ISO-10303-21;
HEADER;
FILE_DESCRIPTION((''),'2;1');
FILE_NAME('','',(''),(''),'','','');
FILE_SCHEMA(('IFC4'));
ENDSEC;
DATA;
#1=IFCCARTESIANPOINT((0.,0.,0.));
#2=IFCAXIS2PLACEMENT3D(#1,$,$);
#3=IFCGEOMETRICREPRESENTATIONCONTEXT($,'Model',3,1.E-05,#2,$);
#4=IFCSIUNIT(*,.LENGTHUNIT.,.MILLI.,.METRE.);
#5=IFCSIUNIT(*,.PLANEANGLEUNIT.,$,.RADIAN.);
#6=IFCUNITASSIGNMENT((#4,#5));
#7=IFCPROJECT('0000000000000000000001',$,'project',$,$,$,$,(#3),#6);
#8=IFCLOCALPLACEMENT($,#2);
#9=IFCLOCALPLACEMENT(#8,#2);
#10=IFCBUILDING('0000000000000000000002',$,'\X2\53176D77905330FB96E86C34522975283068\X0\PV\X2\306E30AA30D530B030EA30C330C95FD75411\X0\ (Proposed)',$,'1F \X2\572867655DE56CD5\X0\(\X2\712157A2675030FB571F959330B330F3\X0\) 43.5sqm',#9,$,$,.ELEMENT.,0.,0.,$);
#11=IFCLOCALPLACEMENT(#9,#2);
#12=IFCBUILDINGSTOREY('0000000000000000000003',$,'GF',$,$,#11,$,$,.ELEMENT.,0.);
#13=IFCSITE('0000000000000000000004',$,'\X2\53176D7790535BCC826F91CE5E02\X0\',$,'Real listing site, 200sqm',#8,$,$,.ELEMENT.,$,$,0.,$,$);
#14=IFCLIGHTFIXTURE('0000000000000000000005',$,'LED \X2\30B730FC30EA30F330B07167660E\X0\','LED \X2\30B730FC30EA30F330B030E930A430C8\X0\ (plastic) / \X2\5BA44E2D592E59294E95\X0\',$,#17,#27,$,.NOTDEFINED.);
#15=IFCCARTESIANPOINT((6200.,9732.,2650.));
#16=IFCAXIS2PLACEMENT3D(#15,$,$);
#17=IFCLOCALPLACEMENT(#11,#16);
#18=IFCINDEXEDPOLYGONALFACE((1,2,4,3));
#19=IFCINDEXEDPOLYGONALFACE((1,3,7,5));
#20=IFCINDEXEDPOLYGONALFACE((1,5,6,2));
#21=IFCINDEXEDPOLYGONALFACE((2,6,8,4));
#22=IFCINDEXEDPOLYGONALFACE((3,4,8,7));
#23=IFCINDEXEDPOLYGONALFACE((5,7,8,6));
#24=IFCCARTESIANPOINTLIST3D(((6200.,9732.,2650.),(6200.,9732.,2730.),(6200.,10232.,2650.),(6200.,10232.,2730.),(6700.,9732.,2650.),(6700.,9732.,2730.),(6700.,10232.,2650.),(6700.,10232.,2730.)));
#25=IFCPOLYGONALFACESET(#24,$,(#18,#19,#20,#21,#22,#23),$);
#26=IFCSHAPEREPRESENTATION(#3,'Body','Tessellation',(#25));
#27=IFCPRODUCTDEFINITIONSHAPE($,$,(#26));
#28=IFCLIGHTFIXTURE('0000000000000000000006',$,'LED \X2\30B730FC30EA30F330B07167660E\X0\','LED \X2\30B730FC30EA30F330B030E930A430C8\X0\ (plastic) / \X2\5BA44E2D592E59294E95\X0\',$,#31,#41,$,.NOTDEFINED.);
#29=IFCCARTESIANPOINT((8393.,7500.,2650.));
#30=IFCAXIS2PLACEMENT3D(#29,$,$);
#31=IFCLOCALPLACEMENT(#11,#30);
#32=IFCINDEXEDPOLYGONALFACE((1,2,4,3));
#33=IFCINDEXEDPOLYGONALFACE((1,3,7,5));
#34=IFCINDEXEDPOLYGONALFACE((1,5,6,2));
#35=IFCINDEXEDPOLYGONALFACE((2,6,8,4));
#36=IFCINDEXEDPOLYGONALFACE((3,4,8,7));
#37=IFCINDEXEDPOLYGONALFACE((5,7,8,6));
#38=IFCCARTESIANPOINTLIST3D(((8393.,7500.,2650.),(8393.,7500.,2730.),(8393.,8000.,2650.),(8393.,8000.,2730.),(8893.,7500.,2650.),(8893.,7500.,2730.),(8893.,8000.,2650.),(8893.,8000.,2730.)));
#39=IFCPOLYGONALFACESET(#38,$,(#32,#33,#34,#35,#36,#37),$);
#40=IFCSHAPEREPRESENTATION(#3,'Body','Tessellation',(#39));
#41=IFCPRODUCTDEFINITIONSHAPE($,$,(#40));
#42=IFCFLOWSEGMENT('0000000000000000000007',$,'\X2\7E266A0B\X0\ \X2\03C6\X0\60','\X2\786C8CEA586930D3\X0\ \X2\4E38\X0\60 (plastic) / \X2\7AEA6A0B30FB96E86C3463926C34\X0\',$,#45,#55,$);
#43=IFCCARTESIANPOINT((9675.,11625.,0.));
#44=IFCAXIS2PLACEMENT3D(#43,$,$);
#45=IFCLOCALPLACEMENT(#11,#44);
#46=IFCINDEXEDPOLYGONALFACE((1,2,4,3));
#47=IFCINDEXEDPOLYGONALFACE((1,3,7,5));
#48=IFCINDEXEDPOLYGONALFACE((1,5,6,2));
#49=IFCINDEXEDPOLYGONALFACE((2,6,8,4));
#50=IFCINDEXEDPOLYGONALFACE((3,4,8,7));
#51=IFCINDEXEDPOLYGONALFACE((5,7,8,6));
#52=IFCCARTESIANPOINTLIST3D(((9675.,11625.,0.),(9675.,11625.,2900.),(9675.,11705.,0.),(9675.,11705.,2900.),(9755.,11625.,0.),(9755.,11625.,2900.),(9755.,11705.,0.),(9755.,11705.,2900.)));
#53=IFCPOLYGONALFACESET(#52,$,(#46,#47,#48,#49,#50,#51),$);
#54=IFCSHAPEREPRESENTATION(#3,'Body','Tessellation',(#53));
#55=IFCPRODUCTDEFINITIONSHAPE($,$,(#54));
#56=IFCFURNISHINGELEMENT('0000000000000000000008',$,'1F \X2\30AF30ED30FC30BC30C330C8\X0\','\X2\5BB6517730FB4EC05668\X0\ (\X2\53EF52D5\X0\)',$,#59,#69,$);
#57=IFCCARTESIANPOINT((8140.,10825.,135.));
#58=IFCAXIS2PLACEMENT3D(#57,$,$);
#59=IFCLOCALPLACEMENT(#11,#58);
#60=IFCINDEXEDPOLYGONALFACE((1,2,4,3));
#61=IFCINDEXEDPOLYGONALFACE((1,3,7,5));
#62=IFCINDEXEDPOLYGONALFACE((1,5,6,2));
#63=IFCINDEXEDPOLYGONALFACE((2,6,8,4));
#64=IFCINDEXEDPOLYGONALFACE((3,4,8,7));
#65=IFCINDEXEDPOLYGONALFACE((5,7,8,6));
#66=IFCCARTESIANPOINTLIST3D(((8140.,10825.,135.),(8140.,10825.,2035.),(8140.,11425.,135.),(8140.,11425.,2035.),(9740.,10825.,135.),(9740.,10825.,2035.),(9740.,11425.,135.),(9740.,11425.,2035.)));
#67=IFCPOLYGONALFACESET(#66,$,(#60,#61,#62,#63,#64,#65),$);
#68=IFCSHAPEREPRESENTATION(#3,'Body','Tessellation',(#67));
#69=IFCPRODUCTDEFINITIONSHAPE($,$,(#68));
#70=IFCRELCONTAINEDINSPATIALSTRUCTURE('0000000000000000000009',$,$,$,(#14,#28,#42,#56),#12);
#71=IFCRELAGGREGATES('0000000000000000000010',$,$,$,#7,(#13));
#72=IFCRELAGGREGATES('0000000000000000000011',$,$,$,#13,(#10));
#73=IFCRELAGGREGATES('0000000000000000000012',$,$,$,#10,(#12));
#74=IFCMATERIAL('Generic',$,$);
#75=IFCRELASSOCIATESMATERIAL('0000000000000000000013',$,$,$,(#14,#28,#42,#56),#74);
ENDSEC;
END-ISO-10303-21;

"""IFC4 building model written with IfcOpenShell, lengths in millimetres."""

from ifc_helpers import new_model, si_unit, frame, frame_2d, origin, place, context, project, spatial, rectangle, extrude, material, element, save


model = new_model("IFC4")

# Units and contexts
model_context = context("Model", 3, precision=1e-05, world=origin())
ifc_project = project(units=[si_unit("LENGTHUNIT", "METRE", prefix="MILLI"), si_unit("PLANEANGLEUNIT", "RADIAN")], contexts=[model_context])

# Site, building, storey
site_placement = place(None, origin())
site = spatial("IfcSite", under=ifc_project, at=site_placement, Name="北海道富良野市", ObjectType="Real listing site, 200sqm", CompositionType="ELEMENT", RefElevation=0.0)
building_placement = place(site_placement, origin())
building = spatial("IfcBuilding", under=site, at=building_placement, Name="北海道・雨水利用とPVのオフグリッド志向 (Proposed)", ObjectType="1F 在来工法(無垢材・土間コン) 43.5sqm", CompositionType="ELEMENT", ElevationOfRefHeight=0.0, ElevationOfTerrain=0.0)
storey_placement = place(building_placement, origin())
storey = spatial("IfcBuildingStorey", under=building, at=storey_placement, Name="GF", CompositionType="ELEMENT", Elevation=0.0)

# Shared definitions
ifc_material_1 = material(Name="Generic")

# Light fixtures
light_fixture_1_placement = place(storey_placement, frame((6200.0, 9732.0, 2650.0)))
element("IfcLightFixture", 1, at=light_fixture_1_placement, inside=storey, material=ifc_material_1, Name="LED シーリング照明", Description="LED シーリングライト (plastic) / 室中央天井", PredefinedType="NOTDEFINED", context=model_context, shape_type="SweptSolid", body=[
    extrude(rectangle(XDim=500.0, YDim=500.0, at=frame_2d((250.0, 250.0))), frame((6200.0, 9732.0, 2650.0)), (0.0, 0.0, 1.0), 80.0),
])
light_fixture_2_placement = place(storey_placement, frame((8393.0, 7500.0, 2650.0)))
element("IfcLightFixture", 2, at=light_fixture_2_placement, inside=storey, material=ifc_material_1, Name="LED シーリング照明", Description="LED シーリングライト (plastic) / 室中央天井", PredefinedType="NOTDEFINED", context=model_context, shape_type="SweptSolid", body=[
    extrude(rectangle(XDim=500.0, YDim=500.0, at=frame_2d((250.0, 250.0))), frame((8393.0, 7500.0, 2650.0)), (0.0, 0.0, 1.0), 80.0),
])

# Flow segment
flow_segment_placement = place(storey_placement, frame((9675.0, 11625.0, 0.0)))
element("IfcFlowSegment", 3, at=flow_segment_placement, inside=storey, material=ifc_material_1, Name="縦樋 φ60", Description="硬質塩ビ 丸60 (plastic) / 竪樋・雨水排水", context=model_context, shape_type="SweptSolid", body=[
    extrude(rectangle(XDim=80.0, YDim=80.0, at=frame_2d((40.0, 40.0))), frame((9675.0, 11625.0, 0.0)), (0.0, 0.0, 1.0), 2900.0),
])

# Furnishing element
furnishing_placement = place(storey_placement, frame((8140.0, 10825.0, 135.0)))
element("IfcFurnishingElement", 4, at=furnishing_placement, inside=storey, material=ifc_material_1, Name="1F クローゼット", Description="家具・什器 (可動)", context=model_context, shape_type="SweptSolid", body=[
    extrude(rectangle(XDim=1600.0, YDim=600.0, at=frame_2d((800.0, 300.0))), frame((8140.0, 10825.0, 135.0)), (0.0, 0.0, 1.0), 1900.0),
])

save(model, "model.ifc")
